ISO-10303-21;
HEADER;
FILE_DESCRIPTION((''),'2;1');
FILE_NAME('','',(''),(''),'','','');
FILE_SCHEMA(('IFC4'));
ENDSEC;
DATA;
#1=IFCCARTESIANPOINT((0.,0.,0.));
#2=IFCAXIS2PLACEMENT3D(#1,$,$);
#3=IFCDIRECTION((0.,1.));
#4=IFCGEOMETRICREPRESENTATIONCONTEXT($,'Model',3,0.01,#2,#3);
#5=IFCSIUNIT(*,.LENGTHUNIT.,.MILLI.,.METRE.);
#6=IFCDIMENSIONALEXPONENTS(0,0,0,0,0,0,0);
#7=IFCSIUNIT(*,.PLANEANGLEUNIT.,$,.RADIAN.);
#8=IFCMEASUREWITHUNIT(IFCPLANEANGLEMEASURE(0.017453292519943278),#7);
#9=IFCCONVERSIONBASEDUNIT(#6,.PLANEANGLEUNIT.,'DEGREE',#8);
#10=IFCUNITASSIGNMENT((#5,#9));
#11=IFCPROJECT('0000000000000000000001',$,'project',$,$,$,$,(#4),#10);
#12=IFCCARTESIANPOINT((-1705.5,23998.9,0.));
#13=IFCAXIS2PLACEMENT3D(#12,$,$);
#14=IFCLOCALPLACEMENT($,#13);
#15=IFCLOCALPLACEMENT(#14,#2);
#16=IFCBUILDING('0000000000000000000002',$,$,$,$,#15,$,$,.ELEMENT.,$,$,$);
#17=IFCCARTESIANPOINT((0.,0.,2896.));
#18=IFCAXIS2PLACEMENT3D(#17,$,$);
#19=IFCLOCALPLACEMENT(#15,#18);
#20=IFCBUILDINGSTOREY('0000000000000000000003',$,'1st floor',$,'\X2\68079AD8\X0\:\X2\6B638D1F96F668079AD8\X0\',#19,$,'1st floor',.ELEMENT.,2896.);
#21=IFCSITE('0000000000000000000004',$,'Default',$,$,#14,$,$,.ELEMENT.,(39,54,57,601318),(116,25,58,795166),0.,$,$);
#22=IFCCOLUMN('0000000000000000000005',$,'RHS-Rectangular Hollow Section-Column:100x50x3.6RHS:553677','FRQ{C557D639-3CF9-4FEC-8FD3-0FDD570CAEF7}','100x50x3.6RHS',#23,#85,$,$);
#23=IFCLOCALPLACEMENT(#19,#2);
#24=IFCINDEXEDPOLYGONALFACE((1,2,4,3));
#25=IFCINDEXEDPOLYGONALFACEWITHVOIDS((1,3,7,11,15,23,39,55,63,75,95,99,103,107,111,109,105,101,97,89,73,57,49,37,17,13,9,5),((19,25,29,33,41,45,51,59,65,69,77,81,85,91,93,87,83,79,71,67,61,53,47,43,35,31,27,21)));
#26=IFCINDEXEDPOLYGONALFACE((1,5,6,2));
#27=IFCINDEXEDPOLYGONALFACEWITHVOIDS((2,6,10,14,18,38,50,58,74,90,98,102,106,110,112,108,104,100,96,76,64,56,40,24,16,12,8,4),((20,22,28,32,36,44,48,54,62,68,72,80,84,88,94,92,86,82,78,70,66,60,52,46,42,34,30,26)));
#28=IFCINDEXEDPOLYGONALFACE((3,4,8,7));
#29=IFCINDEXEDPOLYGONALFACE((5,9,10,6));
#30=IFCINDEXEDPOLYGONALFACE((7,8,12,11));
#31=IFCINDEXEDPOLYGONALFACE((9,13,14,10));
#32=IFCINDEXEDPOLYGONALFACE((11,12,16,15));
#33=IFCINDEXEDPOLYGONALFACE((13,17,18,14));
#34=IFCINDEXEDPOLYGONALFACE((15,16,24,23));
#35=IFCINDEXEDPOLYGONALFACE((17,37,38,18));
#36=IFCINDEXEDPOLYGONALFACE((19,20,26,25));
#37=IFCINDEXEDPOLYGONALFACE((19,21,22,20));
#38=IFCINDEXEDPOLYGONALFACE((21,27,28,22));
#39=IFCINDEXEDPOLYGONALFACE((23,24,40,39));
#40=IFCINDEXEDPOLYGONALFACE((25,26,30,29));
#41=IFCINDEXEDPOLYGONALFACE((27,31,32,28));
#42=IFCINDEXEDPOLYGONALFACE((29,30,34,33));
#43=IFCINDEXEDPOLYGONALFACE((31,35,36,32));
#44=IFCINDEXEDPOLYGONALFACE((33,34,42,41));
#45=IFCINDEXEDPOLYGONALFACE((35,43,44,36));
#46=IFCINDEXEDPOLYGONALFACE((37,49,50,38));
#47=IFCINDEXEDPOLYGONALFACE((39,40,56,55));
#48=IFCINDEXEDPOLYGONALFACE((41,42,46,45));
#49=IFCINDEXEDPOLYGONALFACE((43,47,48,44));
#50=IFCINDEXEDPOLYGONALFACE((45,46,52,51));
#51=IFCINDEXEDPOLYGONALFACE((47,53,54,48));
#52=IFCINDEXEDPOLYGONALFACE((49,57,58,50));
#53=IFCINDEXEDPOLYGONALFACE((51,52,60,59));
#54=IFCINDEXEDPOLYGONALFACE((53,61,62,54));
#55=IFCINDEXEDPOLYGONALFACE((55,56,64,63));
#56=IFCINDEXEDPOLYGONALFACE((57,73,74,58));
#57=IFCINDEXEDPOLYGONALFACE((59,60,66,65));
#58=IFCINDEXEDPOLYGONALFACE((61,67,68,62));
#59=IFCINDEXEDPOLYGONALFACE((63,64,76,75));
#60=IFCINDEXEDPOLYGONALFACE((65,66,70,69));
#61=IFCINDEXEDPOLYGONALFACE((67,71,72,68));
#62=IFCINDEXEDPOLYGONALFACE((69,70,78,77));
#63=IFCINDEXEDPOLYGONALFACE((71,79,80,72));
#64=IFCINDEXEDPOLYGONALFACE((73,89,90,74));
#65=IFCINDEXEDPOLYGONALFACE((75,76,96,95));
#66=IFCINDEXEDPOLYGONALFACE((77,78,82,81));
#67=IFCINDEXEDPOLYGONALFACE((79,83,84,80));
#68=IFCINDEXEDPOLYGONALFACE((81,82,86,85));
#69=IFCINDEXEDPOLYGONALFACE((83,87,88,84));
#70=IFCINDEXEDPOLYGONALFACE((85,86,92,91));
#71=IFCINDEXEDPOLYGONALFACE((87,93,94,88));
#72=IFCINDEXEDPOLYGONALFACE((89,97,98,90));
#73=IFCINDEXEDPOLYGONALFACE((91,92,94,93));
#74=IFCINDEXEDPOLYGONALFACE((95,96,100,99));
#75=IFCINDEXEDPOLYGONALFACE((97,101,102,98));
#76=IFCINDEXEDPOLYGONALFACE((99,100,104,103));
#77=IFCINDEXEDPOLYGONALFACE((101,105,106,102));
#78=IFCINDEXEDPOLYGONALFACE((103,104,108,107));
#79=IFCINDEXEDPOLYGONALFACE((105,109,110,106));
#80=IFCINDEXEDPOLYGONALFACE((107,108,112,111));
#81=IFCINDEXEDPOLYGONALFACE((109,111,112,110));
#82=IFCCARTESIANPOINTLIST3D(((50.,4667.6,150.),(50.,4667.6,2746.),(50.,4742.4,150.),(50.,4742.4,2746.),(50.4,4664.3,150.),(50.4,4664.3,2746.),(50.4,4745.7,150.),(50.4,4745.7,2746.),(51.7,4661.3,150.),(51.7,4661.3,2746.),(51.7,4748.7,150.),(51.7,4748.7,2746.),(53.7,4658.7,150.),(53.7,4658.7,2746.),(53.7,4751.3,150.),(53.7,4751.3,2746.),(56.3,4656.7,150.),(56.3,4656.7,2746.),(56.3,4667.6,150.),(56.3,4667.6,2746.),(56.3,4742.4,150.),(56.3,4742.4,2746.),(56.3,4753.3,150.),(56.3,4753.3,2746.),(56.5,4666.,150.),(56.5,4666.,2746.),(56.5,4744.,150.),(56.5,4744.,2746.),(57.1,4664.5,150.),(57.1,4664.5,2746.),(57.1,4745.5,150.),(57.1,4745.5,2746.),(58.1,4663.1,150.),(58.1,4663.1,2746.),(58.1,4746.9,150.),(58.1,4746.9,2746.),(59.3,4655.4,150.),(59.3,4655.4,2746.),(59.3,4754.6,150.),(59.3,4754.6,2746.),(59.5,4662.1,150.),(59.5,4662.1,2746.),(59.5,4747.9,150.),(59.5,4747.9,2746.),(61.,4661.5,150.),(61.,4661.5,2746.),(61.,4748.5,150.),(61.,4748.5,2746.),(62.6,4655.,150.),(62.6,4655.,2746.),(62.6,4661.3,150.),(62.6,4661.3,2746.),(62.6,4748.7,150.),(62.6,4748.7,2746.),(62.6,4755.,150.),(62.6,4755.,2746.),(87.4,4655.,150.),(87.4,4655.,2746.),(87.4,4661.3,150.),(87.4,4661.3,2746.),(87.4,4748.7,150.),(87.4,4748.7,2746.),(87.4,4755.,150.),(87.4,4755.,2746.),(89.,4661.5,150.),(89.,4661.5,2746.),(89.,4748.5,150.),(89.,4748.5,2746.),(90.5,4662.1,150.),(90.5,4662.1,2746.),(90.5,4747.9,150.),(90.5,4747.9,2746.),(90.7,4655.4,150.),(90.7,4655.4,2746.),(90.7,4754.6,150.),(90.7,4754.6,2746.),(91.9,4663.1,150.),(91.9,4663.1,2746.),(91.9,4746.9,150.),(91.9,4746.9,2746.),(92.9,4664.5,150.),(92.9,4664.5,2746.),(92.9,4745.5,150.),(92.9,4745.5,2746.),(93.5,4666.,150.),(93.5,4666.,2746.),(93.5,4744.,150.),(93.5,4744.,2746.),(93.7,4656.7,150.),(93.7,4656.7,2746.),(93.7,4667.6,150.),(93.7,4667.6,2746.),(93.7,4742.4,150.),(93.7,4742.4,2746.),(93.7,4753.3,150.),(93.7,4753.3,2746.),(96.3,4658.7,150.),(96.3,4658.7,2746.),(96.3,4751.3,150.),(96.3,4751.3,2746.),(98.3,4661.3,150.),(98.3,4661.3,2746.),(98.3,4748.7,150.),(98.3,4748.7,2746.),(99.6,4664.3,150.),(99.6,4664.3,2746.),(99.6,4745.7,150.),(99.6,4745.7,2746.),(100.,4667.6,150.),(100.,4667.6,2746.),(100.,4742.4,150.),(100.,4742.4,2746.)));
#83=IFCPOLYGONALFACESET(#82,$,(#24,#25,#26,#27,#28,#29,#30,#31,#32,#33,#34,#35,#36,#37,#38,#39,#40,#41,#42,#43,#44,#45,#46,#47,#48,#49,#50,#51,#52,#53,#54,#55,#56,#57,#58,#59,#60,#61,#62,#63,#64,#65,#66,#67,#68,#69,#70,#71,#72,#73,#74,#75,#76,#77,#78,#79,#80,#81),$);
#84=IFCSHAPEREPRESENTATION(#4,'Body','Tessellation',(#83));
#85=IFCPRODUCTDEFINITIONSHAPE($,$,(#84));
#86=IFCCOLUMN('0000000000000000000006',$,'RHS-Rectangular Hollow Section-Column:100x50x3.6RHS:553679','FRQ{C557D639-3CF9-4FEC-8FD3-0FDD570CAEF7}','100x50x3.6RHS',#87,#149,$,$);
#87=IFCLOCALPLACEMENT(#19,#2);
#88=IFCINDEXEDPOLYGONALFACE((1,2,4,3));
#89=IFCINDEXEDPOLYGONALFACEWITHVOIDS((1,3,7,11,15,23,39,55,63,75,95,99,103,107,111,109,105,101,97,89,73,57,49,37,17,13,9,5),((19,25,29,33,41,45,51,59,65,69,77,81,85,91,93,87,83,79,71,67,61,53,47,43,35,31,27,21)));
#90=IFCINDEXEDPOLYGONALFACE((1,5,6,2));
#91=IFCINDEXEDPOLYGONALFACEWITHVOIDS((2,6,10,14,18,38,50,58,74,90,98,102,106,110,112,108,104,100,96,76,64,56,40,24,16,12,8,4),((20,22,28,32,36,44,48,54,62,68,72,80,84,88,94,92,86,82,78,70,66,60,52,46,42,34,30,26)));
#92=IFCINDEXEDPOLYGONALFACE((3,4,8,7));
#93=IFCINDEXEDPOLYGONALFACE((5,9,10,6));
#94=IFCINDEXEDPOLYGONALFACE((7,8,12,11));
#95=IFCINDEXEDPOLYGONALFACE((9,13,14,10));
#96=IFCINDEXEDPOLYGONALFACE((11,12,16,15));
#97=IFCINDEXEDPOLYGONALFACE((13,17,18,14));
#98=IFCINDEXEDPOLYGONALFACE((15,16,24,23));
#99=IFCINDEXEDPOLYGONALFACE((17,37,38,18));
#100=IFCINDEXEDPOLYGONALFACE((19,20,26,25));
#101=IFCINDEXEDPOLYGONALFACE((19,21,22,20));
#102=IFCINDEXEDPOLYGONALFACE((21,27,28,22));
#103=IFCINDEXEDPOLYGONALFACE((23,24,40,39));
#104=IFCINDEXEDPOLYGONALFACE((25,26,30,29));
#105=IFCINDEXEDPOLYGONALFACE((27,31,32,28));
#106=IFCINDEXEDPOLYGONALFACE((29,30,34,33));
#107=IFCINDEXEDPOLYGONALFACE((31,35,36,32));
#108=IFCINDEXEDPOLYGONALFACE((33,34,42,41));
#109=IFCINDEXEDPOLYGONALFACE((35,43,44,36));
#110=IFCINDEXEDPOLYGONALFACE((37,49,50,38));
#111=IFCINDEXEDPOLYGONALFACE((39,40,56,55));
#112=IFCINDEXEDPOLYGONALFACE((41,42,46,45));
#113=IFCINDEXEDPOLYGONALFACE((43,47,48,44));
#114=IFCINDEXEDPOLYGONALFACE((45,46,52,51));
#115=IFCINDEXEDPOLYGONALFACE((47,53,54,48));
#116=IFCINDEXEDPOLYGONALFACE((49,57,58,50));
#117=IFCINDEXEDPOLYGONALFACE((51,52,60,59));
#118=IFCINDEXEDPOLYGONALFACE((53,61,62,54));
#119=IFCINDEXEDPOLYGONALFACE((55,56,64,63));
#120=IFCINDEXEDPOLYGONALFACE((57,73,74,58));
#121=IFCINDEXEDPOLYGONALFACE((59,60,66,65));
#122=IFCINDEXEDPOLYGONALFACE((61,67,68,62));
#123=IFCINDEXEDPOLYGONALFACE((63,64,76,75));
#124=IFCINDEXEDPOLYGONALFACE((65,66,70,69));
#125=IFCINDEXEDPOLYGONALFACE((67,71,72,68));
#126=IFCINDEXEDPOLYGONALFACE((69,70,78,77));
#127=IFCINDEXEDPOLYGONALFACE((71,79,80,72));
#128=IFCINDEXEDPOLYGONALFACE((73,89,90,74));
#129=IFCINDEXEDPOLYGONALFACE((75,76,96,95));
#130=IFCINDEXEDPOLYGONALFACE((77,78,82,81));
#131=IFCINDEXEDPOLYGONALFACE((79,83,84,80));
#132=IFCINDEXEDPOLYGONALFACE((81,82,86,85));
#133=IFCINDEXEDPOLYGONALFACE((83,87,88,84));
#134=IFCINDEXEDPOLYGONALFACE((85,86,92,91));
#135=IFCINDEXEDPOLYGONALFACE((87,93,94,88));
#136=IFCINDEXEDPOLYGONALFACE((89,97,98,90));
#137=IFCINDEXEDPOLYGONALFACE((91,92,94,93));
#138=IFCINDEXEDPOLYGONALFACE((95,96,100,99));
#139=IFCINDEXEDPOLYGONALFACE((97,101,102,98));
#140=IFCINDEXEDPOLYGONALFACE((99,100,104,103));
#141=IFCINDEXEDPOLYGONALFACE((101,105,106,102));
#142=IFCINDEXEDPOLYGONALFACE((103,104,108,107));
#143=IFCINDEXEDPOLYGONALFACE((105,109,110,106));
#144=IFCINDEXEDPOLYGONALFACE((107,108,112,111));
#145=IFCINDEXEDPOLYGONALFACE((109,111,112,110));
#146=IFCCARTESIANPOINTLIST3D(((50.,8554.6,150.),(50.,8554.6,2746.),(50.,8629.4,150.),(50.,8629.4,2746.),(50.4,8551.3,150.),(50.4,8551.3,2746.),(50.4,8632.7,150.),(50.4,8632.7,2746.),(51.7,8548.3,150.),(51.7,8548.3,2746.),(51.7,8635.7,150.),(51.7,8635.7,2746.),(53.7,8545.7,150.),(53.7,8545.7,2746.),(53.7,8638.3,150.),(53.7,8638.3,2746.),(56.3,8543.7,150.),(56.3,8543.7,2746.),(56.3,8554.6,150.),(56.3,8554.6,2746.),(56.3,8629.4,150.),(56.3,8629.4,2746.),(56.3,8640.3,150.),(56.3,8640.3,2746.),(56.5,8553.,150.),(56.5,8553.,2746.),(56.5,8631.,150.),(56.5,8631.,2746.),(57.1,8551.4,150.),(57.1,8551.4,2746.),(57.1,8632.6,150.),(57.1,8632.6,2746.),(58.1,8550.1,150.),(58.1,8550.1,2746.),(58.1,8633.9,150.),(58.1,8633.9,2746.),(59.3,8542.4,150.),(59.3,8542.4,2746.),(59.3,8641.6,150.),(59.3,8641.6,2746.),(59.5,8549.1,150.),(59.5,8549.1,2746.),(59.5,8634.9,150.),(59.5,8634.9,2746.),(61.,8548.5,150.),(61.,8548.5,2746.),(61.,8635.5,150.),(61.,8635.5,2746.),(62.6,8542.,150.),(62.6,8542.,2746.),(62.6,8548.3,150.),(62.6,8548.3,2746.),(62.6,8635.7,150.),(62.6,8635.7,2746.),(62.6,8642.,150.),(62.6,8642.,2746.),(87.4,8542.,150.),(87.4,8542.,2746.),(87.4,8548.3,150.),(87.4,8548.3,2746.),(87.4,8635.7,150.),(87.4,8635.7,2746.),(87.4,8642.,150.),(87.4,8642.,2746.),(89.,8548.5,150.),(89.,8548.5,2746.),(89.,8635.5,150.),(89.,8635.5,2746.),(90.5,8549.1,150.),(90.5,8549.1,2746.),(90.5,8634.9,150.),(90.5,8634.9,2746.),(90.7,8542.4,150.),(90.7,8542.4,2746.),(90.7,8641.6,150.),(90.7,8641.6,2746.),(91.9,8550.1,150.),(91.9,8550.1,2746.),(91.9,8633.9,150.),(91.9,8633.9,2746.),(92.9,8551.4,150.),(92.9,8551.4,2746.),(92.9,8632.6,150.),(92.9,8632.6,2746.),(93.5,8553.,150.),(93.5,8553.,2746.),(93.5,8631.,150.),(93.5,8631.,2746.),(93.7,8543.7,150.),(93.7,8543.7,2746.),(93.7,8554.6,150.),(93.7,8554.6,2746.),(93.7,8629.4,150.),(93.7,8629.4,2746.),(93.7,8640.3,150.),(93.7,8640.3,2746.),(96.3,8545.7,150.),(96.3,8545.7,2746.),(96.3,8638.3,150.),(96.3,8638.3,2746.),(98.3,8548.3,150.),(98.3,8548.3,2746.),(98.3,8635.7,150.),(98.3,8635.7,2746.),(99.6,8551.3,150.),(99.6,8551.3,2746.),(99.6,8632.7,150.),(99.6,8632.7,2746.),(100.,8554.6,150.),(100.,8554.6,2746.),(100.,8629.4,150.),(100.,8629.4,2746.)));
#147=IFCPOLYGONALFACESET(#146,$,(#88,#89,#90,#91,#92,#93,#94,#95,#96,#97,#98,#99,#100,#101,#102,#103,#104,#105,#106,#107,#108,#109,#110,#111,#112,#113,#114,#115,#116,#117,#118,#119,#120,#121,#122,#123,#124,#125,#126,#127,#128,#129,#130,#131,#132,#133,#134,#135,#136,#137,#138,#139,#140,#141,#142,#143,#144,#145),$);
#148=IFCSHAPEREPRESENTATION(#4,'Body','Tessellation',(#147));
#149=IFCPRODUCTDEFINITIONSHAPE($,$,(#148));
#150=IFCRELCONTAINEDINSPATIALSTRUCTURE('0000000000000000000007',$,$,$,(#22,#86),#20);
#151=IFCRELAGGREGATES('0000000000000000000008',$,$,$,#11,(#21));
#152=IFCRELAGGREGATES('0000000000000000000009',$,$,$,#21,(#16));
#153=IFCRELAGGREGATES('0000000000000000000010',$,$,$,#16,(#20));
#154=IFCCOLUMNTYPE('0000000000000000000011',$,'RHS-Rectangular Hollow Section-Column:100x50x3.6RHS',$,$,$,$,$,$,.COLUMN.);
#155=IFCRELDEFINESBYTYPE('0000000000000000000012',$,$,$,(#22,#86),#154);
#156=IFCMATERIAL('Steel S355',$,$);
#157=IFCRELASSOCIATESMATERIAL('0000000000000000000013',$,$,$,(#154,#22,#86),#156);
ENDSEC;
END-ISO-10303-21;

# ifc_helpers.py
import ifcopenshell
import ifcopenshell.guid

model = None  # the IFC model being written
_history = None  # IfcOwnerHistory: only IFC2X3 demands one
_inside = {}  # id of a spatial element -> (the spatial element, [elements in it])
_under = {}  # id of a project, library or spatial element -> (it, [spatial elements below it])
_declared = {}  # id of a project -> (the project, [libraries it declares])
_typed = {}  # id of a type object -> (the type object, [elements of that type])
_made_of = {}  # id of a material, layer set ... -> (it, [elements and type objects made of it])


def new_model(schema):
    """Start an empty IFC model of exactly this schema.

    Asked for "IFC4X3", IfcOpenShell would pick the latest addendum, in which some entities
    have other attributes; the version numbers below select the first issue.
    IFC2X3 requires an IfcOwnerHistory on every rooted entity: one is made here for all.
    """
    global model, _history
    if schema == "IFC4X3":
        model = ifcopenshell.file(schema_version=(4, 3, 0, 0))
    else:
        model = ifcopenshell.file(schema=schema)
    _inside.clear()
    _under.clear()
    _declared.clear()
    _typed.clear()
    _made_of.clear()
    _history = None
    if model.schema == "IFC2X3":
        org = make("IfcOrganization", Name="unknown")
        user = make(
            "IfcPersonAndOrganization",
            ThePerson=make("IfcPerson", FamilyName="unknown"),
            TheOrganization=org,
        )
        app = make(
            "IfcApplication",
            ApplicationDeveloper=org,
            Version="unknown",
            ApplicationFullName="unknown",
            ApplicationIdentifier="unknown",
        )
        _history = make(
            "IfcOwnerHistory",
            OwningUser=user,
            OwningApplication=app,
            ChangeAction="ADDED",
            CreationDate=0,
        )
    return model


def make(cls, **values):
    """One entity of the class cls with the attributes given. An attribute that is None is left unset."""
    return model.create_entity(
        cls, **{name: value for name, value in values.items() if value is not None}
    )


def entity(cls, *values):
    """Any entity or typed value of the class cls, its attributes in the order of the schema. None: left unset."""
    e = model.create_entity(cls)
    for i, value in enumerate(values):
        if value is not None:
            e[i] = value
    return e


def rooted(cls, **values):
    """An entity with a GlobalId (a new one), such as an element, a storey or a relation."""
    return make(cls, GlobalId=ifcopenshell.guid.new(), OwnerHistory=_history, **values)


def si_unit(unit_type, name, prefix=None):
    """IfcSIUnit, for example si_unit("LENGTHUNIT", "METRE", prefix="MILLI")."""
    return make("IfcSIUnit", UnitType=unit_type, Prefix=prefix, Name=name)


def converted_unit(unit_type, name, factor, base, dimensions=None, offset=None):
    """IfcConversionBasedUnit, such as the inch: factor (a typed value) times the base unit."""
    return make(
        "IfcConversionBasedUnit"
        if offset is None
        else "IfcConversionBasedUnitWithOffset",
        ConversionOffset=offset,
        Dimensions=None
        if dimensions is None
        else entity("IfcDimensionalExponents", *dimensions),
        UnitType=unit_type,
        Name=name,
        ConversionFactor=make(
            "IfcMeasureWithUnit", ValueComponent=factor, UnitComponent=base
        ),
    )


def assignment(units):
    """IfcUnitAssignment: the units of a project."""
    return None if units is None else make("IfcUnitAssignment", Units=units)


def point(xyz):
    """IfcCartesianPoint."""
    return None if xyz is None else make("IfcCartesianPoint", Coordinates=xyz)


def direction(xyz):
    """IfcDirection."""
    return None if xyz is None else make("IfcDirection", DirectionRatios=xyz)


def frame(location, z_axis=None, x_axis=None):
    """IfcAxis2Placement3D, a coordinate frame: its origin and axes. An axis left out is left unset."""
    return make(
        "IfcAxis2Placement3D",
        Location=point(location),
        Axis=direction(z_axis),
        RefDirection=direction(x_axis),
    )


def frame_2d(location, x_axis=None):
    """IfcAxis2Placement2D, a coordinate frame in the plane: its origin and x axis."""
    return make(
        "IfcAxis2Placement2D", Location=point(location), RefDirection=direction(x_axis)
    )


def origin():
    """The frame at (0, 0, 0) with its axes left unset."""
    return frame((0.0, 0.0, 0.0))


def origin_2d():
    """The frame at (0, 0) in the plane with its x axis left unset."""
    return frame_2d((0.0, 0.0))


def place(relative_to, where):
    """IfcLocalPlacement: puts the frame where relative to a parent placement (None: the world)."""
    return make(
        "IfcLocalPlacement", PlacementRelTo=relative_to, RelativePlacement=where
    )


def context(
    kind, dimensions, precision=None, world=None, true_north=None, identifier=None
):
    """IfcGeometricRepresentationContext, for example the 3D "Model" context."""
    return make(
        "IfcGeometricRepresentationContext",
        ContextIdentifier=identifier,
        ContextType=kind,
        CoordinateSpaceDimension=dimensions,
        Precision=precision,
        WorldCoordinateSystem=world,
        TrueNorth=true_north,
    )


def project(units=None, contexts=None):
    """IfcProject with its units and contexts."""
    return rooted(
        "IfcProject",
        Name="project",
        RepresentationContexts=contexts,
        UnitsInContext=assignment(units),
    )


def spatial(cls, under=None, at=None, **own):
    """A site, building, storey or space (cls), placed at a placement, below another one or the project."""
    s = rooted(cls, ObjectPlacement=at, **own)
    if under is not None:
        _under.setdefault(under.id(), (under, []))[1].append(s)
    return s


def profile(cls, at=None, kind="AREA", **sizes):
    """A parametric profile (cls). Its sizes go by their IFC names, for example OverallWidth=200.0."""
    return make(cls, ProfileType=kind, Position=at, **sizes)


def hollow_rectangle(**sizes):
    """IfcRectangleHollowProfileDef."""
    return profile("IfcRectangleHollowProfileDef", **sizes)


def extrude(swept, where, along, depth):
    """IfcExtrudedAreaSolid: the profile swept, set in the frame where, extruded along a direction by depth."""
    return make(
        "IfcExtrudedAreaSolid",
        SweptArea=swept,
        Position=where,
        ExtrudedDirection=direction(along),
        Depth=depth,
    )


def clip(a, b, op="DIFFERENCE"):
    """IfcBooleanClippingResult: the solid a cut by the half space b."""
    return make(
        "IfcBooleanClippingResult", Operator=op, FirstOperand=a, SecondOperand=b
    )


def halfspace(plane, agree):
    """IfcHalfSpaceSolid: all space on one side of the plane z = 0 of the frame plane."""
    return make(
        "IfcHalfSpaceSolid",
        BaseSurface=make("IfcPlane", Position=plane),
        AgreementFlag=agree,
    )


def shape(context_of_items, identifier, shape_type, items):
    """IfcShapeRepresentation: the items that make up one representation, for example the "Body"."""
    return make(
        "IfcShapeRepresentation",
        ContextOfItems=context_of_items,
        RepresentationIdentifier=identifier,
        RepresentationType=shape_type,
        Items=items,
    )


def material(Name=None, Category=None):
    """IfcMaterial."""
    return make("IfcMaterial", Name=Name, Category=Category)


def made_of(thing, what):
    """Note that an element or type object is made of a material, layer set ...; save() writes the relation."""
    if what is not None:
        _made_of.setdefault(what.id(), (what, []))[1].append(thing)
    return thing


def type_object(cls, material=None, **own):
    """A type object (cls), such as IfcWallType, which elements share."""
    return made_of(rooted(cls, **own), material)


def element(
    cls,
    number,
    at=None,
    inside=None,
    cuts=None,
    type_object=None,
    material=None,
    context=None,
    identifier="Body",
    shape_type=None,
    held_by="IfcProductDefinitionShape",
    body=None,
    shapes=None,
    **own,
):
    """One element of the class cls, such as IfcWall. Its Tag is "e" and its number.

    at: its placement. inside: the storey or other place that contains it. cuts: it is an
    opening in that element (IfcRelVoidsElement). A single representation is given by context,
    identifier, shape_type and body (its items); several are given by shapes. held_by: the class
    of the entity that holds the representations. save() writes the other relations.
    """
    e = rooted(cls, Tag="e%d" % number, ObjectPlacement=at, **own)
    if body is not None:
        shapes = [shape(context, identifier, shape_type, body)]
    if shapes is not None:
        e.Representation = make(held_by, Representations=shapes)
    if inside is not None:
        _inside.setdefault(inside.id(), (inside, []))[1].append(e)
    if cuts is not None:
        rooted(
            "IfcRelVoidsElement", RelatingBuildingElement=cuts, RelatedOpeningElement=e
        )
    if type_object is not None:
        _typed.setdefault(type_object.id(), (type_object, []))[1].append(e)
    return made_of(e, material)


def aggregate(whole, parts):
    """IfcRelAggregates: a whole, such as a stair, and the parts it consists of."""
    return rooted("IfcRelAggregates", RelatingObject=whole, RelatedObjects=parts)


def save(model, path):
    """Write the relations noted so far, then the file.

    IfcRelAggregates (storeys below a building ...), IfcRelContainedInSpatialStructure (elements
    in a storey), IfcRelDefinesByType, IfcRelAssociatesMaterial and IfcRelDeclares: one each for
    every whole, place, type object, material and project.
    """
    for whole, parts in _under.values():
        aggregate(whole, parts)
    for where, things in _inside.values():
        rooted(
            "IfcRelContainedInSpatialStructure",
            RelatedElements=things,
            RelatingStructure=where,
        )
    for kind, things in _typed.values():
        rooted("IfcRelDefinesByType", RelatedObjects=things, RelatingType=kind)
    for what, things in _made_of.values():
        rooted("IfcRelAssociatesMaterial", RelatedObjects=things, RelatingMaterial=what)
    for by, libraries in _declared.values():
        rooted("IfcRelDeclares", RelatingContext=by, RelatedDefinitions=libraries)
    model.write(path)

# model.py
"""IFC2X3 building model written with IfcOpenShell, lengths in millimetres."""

from ifc_helpers import new_model, entity, si_unit, converted_unit, direction, frame, origin, origin_2d, place, context, project, spatial, hollow_rectangle, extrude, clip, halfspace, material, type_object, element, save


model = new_model("IFC2X3")

# Units and contexts
model_context = context("Model", 3, precision=0.01, world=origin(), true_north=direction((0.0, 1.0)))
ifc_project = project(units=[si_unit("LENGTHUNIT", "METRE", prefix="MILLI"), converted_unit("PLANEANGLEUNIT", "DEGREE", entity("IfcPlaneAngleMeasure", 0.017453292519943278), si_unit("PLANEANGLEUNIT", "RADIAN"), dimensions=[0, 0, 0, 0, 0, 0, 0])], contexts=[model_context])

# Site, building, storey
site_placement = place(None, frame((-1705.5, 23998.9, 0.0)))
site = spatial("IfcSite", under=ifc_project, at=site_placement, Name="Default", CompositionType="ELEMENT", RefLatitude=(39, 54, 57, 601318), RefLongitude=(116, 25, 58, 795166), RefElevation=0.0)
building_placement = place(site_placement, origin())
building = spatial("IfcBuilding", under=site, at=building_placement, CompositionType="ELEMENT")
storey_placement = place(building_placement, frame((0.0, 0.0, 2896.0)))
storey = spatial("IfcBuildingStorey", under=building, at=storey_placement, Name="1st floor", ObjectType="标高:正负零标高", LongName="1st floor", CompositionType="ELEMENT", Elevation=2896.0)

# Columns
ifc_material_1 = material(Name="Steel S355")
column_type = type_object("IfcColumnType", Name="RHS-Rectangular Hollow Section-Column:100x50x3.6RHS", PredefinedType="COLUMN", material=ifc_material_1)
column_1_placement = place(storey_placement, frame((75.0, 4705.0, 2746.0), z_axis=(0.0, 0.0, 1.0), x_axis=(-1.0, 0.0, 0.0)))
element("IfcColumn", 1, at=column_1_placement, inside=storey, type_object=column_type, material=ifc_material_1, Name="RHS-Rectangular Hollow Section-Column:100x50x3.6RHS:553677", Description="FRQ{C557D639-3CF9-4FEC-8FD3-0FDD570CAEF7}", ObjectType="100x50x3.6RHS", context=model_context, shape_type="Clipping", body=[
    clip(extrude(hollow_rectangle(XDim=50.0, YDim=100.0, WallThickness=6.3, InnerFilletRadius=6.3, OuterFilletRadius=12.6, at=origin_2d()), origin(), (0.0, 0.0, -1.0), 2651.9), halfspace(frame((75.0, 4705.0, -2596.0), z_axis=(0.0, 0.0, 1.0), x_axis=(-1.0, 0.0, 0.0)), True)),
])
column_2_placement = place(storey_placement, frame((75.0, 8592.0, 2746.0), z_axis=(0.0, 0.0, 1.0), x_axis=(-1.0, 0.0, 0.0)))
element("IfcColumn", 2, at=column_2_placement, inside=storey, type_object=column_type, material=ifc_material_1, Name="RHS-Rectangular Hollow Section-Column:100x50x3.6RHS:553679", Description="FRQ{C557D639-3CF9-4FEC-8FD3-0FDD570CAEF7}", ObjectType="100x50x3.6RHS", context=model_context, shape_type="Clipping", body=[
    clip(extrude(hollow_rectangle(XDim=50.0, YDim=100.0, WallThickness=6.3, InnerFilletRadius=6.3, OuterFilletRadius=12.6, at=origin_2d()), origin(), (0.0, 0.0, -1.0), 2651.9), halfspace(frame((75.0, 8592.0, -2596.0), z_axis=(0.0, 0.0, 1.0), x_axis=(-1.0, 0.0, 0.0)), True)),
])

save(model, "model.ifc")
